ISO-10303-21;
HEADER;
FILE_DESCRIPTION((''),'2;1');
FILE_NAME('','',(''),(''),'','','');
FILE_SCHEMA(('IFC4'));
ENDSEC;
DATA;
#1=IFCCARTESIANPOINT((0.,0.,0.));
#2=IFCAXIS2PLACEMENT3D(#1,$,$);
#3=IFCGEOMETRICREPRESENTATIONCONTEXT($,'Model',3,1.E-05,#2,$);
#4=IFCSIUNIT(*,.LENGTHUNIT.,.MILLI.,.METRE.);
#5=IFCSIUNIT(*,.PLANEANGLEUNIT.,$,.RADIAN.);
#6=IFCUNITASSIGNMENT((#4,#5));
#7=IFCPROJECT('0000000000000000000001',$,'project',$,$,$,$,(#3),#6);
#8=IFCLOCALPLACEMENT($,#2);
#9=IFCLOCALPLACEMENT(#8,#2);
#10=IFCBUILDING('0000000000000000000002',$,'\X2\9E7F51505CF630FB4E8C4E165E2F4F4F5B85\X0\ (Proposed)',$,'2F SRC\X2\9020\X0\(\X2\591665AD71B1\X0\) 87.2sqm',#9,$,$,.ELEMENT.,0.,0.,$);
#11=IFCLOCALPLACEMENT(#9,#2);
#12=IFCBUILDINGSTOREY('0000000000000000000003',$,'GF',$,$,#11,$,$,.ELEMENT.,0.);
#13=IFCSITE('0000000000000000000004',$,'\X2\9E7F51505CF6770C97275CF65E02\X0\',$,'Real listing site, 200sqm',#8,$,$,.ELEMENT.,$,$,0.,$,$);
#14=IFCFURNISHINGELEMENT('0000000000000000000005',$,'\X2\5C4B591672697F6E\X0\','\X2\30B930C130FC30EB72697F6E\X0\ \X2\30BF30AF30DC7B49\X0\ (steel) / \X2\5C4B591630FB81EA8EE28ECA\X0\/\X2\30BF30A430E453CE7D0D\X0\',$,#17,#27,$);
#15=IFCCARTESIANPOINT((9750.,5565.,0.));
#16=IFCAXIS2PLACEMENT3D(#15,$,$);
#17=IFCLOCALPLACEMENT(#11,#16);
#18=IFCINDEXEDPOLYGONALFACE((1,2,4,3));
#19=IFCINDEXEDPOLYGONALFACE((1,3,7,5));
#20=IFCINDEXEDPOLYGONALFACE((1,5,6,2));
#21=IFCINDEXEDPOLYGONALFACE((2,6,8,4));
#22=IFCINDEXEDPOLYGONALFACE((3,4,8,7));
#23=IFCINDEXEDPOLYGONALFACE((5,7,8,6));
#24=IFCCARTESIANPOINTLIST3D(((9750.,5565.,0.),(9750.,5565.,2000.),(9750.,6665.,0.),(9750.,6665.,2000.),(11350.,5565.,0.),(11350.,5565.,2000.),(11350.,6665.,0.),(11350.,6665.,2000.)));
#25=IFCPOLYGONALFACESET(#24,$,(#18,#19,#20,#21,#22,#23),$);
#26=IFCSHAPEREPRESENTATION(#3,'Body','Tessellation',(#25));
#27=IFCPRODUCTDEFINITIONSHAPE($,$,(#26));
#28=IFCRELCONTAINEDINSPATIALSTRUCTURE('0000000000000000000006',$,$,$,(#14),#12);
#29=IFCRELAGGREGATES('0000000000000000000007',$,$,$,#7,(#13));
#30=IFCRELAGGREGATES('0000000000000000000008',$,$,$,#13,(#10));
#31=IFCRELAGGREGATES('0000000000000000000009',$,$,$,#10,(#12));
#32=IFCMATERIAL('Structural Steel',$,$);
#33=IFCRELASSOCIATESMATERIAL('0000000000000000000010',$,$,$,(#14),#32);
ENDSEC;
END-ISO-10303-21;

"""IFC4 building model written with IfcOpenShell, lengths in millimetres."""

from ifc_helpers import new_model, si_unit, frame, frame_2d, origin, place, context, project, spatial, rectangle, extrude, material, element, save


model = new_model("IFC4")

# Units and contexts
model_context = context("Model", 3, precision=1e-05, world=origin())
ifc_project = project(units=[si_unit("LENGTHUNIT", "METRE", prefix="MILLI"), si_unit("PLANEANGLEUNIT", "RADIAN")], contexts=[model_context])

# Site, building, storey
site_placement = place(None, origin())
site = spatial("IfcSite", under=ifc_project, at=site_placement, Name="鹿児島県霧島市", ObjectType="Real listing site, 200sqm", CompositionType="ELEMENT", RefElevation=0.0)
building_placement = place(site_placement, origin())
building = spatial("IfcBuilding", under=site, at=building_placement, Name="鹿児島・二世帯住宅 (Proposed)", ObjectType="2F SRC造(外断熱) 87.2sqm", CompositionType="ELEMENT", ElevationOfRefHeight=0.0, ElevationOfTerrain=0.0)
storey_placement = place(building_placement, origin())
storey = spatial("IfcBuildingStorey", under=building, at=storey_placement, Name="GF", CompositionType="ELEMENT", Elevation=0.0)

# Shared definitions
ifc_material_1 = material(Name="Structural Steel")

# Furnishing element
furnishing_1_placement = place(storey_placement, frame((9750.0, 5565.0, 0.0)))
element("IfcFurnishingElement", 1, at=furnishing_1_placement, inside=storey, material=ifc_material_1, Name="屋外物置", Description="スチール物置 タクボ等 (steel) / 屋外・自転車/タイヤ収納", context=model_context, shape_type="SweptSolid", body=[
    extrude(rectangle(XDim=1600.0, YDim=1100.0, at=frame_2d((800.0, 550.0))), frame((9750.0, 5565.0, 0.0)), (0.0, 0.0, 1.0), 2000.0),
])

save(model, "model.ifc")
